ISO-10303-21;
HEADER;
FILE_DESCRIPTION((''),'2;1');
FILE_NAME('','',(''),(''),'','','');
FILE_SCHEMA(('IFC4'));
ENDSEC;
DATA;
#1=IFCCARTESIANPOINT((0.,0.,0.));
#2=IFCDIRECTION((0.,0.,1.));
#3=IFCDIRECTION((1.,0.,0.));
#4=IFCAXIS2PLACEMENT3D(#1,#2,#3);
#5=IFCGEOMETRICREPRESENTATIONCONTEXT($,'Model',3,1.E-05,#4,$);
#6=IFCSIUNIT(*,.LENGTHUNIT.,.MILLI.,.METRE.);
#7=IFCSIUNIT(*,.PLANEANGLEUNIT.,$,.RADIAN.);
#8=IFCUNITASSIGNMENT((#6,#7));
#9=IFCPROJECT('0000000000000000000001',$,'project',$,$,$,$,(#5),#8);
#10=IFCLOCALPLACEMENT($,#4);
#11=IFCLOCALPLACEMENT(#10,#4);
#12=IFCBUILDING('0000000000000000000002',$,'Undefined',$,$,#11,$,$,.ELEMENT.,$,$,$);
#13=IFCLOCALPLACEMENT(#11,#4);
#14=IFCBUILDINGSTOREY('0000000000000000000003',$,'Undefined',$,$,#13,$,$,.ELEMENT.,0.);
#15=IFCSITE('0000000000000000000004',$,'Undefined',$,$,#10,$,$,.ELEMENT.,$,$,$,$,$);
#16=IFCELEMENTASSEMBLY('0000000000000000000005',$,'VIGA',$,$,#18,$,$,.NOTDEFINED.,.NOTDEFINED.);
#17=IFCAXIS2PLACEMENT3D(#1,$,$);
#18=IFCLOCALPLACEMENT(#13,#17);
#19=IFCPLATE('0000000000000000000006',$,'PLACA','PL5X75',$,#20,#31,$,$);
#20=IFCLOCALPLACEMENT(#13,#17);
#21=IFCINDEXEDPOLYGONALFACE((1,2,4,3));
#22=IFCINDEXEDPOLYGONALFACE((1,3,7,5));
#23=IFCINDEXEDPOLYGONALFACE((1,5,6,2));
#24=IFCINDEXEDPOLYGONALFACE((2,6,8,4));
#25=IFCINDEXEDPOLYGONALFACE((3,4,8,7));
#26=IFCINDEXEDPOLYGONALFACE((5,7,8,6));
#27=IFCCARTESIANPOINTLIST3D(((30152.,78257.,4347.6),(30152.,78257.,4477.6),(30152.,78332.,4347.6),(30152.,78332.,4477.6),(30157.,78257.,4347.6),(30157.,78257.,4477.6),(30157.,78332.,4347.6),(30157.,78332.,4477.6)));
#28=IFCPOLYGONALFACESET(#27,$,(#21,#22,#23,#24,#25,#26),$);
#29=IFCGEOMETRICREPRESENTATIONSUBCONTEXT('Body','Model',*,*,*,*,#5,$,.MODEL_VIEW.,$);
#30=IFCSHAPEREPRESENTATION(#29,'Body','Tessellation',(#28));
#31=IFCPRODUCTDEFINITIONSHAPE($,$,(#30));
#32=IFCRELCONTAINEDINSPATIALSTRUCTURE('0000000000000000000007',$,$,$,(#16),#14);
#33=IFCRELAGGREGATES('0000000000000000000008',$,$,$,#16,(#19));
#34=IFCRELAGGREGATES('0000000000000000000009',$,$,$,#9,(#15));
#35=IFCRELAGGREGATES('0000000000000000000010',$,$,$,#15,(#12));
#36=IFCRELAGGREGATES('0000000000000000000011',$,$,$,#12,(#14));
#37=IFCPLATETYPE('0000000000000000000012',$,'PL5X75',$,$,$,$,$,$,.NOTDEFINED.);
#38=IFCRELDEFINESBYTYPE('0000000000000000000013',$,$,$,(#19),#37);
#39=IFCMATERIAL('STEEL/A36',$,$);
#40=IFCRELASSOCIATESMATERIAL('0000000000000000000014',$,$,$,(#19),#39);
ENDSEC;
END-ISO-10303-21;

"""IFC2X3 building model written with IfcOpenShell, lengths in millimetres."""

from ifc_helpers import new_model, si_unit, frame, origin_with_axes, place, context, subcontext, project, spatial, polyline, outline, extrude, material, type_object, element, aggregate, save


model = new_model("IFC2X3")

# Units and contexts
model_context = context("Model", 3, precision=1e-05, world=origin_with_axes())
body_context = subcontext(model_context, "Body", "Model", "MODEL_VIEW")
ifc_project = project(units=[si_unit("LENGTHUNIT", "METRE", prefix="MILLI"), si_unit("PLANEANGLEUNIT", "RADIAN")], contexts=[model_context])

# Site, building, storey
site_placement = place(None, origin_with_axes())
site = spatial("IfcSite", under=ifc_project, at=site_placement, Name="Undefined", CompositionType="ELEMENT")
building_placement = place(site_placement, origin_with_axes())
building = spatial("IfcBuilding", under=site, at=building_placement, Name="Undefined", CompositionType="ELEMENT")
storey_placement = place(building_placement, origin_with_axes())
storey = spatial("IfcBuildingStorey", under=building, at=storey_placement, Name="Undefined", CompositionType="ELEMENT", Elevation=0.0)

# Element assembly
assembly_1_placement = place(storey_placement, origin_with_axes())
assembly_1 = element("IfcElementAssembly", 1, at=assembly_1_placement, inside=storey, Name="VIGA", AssemblyPlace="NOTDEFINED", PredefinedType="NOTDEFINED")
ifc_material_1 = material(Name="STEEL/A36")

# Plate
plate_type_1 = type_object("IfcPlateType", Name="PL5X75", PredefinedType="NOTDEFINED")
plate_1_placement = place(assembly_1_placement, frame((30154.5, 78257.0, 4477.6), z_axis=(-1.0, 0.000023, 0.0), x_axis=(0.000023, 1.0, 0.0)))
plate_1 = element("IfcPlate", 2, at=plate_1_placement, type_object=plate_type_1, material=ifc_material_1, Name="PLACA", Description="PL5X75", context=body_context, shape_type="SweptSolid", body=[
    extrude(outline(polyline([(0.0, 0.0), (75.0, 0.0), (75.0, 130.0), (0.0, 130.0), (0.0, 0.0)])), frame((0.0, 0.0, -2.5), z_axis=(0.0, 0.0, 1.0), x_axis=(1.0, 0.0, 0.0)), (0.0, 0.0, 1.0), 5.0),
])
aggregate(assembly_1, [plate_1])

save(model, "model.ifc")
